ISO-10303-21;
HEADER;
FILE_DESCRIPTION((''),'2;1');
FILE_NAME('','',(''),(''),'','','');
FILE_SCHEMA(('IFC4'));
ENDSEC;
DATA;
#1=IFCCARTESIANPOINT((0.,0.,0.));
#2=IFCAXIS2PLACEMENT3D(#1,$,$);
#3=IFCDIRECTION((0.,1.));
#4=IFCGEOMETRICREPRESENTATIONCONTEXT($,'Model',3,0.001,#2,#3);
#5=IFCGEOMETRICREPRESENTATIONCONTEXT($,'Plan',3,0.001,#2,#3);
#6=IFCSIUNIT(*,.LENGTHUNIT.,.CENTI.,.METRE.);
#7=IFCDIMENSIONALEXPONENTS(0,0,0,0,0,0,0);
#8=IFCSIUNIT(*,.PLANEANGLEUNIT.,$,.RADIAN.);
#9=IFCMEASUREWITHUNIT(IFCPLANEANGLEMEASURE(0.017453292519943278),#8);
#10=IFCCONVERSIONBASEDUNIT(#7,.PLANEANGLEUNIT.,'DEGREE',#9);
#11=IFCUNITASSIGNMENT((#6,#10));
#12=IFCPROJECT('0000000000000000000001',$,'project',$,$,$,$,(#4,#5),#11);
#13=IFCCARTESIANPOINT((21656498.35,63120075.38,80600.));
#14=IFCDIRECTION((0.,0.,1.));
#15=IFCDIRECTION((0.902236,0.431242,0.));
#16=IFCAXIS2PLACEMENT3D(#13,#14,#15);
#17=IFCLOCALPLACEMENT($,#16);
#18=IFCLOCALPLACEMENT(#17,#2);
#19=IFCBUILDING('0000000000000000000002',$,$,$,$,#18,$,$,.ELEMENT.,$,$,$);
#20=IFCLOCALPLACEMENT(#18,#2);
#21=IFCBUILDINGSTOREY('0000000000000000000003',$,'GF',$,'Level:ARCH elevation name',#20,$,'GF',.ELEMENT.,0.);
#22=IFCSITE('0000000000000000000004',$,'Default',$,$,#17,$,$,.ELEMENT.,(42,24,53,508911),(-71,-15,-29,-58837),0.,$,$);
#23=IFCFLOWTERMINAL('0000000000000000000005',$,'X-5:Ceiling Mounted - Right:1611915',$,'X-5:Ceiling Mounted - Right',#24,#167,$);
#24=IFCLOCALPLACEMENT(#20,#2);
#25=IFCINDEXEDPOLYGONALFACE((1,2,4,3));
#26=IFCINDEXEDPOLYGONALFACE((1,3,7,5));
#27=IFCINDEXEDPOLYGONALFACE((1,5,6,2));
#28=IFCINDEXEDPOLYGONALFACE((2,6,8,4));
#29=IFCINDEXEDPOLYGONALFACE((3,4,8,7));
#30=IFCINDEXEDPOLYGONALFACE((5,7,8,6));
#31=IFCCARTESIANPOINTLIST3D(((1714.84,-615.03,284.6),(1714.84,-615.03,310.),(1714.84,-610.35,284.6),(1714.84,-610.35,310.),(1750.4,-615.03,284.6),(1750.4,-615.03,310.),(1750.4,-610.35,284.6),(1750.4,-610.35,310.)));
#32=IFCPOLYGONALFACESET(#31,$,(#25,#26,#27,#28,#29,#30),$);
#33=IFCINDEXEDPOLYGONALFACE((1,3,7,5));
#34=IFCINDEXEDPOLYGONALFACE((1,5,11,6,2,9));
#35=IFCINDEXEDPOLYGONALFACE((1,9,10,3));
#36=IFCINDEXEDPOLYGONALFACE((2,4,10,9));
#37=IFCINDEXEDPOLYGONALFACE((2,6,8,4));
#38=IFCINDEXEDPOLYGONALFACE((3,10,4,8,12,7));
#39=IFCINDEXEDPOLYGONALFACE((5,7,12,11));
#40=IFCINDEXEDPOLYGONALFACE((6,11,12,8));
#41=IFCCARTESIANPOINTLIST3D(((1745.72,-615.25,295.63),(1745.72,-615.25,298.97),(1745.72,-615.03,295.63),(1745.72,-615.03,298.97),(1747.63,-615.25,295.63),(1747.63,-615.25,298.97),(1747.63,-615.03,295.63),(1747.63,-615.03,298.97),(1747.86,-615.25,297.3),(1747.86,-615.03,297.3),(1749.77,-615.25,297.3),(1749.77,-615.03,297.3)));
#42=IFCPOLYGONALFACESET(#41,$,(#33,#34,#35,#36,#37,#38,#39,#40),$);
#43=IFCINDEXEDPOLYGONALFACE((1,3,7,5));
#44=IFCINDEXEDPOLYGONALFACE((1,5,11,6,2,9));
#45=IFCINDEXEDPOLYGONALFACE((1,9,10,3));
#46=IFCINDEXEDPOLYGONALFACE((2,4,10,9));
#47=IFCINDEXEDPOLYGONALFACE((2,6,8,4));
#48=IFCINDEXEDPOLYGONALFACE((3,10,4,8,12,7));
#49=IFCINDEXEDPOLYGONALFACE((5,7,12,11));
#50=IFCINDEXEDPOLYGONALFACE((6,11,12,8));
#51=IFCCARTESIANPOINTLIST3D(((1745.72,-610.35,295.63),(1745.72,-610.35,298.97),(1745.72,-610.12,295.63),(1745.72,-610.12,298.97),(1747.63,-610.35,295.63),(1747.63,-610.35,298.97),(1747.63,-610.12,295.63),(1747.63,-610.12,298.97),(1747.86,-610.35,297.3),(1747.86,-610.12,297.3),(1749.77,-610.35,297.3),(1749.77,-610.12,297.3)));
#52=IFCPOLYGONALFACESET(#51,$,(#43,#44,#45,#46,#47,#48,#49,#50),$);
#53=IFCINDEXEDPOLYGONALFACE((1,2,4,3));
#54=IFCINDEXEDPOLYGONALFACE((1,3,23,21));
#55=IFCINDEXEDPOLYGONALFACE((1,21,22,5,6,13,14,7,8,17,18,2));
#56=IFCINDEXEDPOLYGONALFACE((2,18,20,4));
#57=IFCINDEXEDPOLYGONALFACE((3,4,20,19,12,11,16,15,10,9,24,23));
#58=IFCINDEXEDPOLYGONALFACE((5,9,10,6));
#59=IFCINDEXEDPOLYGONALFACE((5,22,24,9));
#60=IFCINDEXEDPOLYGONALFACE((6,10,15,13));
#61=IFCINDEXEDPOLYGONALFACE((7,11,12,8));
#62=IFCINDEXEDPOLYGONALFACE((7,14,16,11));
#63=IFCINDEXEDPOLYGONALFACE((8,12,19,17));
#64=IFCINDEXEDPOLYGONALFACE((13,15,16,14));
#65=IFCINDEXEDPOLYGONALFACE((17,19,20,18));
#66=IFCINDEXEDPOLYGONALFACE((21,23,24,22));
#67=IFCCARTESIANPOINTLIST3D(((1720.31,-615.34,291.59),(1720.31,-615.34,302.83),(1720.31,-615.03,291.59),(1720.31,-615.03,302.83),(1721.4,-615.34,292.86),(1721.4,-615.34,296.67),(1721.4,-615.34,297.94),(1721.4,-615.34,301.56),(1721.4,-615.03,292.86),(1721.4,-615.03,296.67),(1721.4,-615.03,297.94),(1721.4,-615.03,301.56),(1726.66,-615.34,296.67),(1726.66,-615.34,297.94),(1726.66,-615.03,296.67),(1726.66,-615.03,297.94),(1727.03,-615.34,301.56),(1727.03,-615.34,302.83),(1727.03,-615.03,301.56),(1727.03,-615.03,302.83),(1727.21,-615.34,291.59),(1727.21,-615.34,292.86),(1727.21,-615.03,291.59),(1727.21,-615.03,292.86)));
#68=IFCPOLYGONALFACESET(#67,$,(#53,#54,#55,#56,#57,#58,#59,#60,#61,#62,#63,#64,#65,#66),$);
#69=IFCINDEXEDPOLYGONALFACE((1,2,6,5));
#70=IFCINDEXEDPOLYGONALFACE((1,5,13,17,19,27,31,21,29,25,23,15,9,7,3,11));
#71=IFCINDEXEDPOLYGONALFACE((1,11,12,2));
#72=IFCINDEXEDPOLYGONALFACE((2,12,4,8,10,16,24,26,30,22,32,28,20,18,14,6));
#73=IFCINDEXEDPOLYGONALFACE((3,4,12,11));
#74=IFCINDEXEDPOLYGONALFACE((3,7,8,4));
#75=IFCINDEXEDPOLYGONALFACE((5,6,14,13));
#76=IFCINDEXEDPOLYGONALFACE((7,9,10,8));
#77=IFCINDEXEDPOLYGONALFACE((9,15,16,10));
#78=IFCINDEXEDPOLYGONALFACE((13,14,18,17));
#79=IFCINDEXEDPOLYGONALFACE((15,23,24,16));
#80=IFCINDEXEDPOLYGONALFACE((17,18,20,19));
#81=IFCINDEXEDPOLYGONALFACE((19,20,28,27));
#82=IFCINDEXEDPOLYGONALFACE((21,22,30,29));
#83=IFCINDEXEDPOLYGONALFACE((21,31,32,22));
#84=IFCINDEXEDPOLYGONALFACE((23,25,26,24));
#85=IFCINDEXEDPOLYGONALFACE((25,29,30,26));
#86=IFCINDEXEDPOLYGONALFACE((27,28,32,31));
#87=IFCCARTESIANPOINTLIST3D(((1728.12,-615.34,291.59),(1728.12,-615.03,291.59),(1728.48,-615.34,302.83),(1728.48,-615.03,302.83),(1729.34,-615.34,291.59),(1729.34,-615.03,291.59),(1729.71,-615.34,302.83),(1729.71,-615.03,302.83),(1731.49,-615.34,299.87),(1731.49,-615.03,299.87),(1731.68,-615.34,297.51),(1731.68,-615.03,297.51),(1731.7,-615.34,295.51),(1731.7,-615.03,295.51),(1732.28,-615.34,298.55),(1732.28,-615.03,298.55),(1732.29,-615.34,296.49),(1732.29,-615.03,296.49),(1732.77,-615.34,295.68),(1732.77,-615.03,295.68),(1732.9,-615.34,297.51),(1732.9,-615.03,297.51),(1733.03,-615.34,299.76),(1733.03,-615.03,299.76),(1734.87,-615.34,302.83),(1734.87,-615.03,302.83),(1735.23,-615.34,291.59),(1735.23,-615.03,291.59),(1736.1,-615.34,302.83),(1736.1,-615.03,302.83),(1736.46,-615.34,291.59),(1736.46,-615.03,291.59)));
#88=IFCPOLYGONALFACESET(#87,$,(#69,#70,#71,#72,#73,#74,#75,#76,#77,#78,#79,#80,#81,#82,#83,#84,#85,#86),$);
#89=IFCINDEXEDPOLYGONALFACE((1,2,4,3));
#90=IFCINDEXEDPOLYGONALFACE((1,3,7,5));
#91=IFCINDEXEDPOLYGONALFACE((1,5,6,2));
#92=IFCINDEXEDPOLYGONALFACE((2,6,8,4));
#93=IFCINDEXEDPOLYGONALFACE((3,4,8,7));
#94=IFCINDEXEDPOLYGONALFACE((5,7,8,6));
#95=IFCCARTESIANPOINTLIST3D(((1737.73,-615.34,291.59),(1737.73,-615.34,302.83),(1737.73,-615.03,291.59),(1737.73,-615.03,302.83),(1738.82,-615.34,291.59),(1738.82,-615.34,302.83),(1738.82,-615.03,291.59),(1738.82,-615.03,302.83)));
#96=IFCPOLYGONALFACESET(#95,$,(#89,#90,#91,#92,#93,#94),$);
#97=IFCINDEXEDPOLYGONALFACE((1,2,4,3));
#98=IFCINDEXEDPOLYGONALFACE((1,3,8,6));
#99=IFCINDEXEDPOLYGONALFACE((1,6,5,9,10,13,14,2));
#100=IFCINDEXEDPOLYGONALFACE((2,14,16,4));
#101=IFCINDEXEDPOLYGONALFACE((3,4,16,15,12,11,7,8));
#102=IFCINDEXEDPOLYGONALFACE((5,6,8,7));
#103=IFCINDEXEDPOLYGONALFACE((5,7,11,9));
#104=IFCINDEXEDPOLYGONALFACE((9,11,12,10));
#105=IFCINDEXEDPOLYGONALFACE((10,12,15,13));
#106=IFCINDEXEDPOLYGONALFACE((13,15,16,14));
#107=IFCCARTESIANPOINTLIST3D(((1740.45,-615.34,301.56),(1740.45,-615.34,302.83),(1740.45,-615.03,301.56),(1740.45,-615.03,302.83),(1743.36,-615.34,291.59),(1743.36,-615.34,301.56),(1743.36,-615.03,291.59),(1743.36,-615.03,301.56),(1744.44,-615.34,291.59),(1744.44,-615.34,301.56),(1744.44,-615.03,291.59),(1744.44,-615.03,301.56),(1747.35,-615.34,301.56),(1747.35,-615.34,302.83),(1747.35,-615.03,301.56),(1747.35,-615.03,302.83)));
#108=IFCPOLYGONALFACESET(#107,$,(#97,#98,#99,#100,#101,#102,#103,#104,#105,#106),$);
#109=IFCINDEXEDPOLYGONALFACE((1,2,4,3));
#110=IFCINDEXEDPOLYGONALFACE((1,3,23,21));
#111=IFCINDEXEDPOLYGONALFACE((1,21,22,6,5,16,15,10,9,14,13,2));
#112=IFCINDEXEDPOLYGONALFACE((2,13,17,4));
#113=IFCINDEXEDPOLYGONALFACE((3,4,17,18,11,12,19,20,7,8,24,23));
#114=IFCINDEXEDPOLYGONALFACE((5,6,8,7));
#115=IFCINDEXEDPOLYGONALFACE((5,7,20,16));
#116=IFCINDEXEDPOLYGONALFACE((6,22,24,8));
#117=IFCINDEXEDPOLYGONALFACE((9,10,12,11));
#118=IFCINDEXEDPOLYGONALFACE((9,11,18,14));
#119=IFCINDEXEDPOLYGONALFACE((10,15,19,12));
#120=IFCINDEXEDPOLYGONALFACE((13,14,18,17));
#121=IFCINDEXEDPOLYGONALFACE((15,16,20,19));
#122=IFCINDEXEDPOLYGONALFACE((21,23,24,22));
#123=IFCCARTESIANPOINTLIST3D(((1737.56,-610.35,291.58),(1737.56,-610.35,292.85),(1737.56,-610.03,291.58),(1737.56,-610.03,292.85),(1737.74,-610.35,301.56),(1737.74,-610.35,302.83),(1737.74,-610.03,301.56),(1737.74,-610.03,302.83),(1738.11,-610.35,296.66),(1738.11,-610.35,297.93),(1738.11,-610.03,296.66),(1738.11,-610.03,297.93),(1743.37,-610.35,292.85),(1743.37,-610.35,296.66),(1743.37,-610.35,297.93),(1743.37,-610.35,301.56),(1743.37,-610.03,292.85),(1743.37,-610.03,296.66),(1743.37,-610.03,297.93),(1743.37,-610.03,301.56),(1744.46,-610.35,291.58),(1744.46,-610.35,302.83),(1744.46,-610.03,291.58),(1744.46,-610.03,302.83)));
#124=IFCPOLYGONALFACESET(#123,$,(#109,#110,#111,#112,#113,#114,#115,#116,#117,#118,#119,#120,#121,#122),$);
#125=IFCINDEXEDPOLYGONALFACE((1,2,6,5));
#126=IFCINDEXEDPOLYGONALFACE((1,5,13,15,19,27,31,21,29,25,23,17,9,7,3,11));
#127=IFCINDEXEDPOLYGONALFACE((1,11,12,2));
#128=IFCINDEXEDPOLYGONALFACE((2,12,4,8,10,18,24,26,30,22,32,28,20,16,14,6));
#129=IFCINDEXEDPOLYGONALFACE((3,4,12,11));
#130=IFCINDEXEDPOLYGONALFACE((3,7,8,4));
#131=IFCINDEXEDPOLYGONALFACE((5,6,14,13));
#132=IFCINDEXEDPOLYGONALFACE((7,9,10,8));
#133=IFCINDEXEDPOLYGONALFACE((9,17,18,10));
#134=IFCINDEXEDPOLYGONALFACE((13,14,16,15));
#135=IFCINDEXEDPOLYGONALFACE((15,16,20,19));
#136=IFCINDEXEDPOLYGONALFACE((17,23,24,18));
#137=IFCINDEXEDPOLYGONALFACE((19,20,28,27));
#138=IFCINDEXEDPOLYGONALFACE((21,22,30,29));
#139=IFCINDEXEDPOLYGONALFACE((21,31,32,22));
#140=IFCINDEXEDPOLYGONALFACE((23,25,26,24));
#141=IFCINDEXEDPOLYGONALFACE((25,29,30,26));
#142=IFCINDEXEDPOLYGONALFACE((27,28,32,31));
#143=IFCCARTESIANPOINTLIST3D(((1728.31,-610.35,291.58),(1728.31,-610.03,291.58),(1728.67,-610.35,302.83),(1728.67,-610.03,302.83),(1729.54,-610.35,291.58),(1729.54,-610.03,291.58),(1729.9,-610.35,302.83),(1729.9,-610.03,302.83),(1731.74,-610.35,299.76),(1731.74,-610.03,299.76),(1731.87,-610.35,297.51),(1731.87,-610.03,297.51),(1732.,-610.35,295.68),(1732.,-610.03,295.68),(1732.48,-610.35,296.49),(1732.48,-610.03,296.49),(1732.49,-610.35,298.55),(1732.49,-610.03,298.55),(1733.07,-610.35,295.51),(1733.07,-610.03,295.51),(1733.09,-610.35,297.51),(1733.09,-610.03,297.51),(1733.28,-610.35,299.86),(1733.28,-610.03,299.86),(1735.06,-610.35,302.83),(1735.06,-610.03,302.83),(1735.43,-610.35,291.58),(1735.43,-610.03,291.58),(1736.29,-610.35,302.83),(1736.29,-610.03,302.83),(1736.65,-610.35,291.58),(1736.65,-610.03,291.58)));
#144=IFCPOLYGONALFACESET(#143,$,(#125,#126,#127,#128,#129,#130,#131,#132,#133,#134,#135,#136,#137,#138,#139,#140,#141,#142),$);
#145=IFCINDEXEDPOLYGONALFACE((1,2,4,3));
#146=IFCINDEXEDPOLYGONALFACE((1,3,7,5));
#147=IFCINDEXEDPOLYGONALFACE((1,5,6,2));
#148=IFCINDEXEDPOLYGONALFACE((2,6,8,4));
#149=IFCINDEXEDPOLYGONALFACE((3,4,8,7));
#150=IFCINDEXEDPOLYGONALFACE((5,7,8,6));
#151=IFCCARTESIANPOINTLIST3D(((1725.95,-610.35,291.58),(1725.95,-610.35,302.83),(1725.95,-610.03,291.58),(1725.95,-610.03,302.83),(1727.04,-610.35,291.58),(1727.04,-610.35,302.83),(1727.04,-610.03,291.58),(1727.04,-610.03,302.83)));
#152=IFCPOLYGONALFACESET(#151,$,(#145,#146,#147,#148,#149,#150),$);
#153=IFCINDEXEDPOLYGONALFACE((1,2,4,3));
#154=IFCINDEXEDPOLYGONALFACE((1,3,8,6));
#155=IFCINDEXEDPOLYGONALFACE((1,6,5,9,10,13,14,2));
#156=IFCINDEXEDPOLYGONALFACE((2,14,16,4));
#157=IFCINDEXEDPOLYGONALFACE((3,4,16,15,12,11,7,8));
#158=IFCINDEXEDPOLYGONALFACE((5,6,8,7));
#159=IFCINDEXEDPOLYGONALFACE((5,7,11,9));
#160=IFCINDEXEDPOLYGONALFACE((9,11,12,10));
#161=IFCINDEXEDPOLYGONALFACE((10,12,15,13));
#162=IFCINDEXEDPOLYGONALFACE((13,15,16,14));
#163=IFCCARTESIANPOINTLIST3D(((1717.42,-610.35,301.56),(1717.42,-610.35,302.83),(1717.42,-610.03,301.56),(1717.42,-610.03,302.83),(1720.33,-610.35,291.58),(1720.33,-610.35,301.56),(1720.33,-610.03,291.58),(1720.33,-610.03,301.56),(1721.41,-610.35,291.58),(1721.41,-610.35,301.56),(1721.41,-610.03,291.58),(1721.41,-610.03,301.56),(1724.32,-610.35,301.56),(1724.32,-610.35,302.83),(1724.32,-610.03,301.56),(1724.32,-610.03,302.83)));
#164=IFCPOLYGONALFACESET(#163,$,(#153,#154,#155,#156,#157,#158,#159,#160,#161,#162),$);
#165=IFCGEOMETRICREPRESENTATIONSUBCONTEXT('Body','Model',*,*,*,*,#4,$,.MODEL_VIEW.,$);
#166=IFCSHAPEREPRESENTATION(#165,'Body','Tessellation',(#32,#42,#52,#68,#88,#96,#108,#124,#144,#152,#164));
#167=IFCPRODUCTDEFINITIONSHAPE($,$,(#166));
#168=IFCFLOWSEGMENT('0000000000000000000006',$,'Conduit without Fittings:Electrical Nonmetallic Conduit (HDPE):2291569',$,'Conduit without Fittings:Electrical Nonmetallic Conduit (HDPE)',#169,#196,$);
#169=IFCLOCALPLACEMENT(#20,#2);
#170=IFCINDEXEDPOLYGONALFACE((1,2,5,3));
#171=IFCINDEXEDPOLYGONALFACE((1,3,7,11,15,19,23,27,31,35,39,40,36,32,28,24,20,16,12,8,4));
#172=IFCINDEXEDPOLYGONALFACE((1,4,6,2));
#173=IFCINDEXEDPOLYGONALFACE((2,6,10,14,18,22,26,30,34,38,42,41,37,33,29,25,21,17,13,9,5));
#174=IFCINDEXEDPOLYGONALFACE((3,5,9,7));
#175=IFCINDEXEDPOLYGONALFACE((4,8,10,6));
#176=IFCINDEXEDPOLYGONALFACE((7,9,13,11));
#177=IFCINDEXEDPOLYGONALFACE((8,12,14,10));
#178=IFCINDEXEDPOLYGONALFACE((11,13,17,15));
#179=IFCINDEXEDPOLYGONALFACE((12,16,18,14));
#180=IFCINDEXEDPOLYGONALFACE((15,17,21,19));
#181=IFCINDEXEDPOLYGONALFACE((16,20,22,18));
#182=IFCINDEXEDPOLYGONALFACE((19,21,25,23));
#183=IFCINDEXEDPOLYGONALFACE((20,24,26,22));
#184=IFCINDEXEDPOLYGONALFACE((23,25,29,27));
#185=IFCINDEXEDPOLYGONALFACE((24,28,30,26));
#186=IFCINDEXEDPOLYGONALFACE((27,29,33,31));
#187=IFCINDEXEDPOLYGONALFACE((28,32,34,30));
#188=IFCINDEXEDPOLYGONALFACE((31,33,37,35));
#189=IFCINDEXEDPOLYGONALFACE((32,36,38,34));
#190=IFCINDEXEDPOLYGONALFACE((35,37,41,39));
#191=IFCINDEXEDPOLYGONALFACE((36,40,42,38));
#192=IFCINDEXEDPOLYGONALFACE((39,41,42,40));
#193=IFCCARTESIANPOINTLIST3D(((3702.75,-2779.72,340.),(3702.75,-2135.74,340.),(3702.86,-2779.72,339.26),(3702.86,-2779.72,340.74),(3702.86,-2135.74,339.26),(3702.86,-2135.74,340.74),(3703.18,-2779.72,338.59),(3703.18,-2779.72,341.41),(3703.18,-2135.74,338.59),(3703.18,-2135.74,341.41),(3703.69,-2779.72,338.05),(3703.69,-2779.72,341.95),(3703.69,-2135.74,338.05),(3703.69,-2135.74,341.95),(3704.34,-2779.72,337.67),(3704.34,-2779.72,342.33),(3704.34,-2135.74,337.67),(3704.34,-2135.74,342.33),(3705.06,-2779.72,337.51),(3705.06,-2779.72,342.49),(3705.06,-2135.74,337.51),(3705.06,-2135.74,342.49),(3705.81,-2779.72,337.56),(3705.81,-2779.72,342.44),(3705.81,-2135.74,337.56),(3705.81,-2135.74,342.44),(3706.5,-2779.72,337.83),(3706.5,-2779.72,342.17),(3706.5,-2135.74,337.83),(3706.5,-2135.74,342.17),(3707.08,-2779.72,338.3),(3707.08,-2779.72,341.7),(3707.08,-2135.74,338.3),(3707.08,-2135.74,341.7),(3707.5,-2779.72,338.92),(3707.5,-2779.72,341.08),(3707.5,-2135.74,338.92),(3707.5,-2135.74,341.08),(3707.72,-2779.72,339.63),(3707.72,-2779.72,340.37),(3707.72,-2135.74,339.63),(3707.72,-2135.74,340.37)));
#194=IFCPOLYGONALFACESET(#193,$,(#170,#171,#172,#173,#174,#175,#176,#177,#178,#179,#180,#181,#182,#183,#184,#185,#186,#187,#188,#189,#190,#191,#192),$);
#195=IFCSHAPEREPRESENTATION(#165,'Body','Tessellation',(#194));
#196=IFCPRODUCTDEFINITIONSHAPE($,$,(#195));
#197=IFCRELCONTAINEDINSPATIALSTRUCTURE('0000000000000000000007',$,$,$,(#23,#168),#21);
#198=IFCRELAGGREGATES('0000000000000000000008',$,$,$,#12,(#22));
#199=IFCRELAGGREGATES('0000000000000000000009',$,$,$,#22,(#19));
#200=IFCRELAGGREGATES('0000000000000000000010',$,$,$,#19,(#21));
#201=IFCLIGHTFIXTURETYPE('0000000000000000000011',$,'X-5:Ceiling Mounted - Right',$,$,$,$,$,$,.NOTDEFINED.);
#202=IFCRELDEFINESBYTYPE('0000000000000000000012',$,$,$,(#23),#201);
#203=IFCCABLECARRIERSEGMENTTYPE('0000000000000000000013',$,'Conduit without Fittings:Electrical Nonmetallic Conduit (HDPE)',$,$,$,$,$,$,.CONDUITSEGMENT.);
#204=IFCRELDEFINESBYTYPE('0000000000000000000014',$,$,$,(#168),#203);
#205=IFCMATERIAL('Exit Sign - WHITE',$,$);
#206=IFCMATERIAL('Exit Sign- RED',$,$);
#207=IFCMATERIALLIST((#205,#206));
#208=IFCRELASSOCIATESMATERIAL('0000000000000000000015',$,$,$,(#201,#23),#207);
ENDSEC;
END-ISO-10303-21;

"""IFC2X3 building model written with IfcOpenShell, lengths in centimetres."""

from ifc_helpers import new_model, entity, si_unit, converted_unit, direction, frame, frame_2d, origin, place, context, subcontext, project, spatial, polyline, rectangle, circle, outline, extrude, source, transform, mapped, material, material_list, type_object, type_shapes, element, save


model = new_model("IFC2X3")

# Units and contexts
model_context = context("Model", 3, precision=0.001, world=origin(), true_north=direction((0.0, 1.0)))
plan_context = context("Plan", 3, precision=0.001, world=origin(), true_north=direction((0.0, 1.0)))
body_context = subcontext(model_context, "Body", "Model", "MODEL_VIEW")
ifc_project = project(units=[si_unit("LENGTHUNIT", "METRE", prefix="CENTI"), converted_unit("PLANEANGLEUNIT", "DEGREE", entity("IfcPlaneAngleMeasure", 0.017453292519943278), si_unit("PLANEANGLEUNIT", "RADIAN"), dimensions=[0, 0, 0, 0, 0, 0, 0])], contexts=[model_context, plan_context])

# Site, building, storey
site_placement = place(None, frame((21656498.35, 63120075.38, 80600.0), z_axis=(0.0, 0.0, 1.0), x_axis=(0.902236, 0.431242, 0.0)))
site = spatial("IfcSite", under=ifc_project, at=site_placement, Name="Default", CompositionType="ELEMENT", RefLatitude=(42, 24, 53, 508911), RefLongitude=(-71, -15, -29, -58837), RefElevation=0.0)
building_placement = place(site_placement, origin())
building = spatial("IfcBuilding", under=site, at=building_placement, CompositionType="ELEMENT")
storey_placement = place(building_placement, origin())
storey = spatial("IfcBuildingStorey", under=building, at=storey_placement, Name="GF", ObjectType="Level:ARCH elevation name", LongName="GF", CompositionType="ELEMENT", Elevation=0.0)

# Flow terminal
ifc_material_1 = material(Name="Exit Sign - WHITE")
ifc_material_2 = material(Name="Exit Sign- RED")
ifc_material_list_1 = material_list([ifc_material_1, ifc_material_2])
light_fixture_type_1 = type_object("IfcLightFixtureType", Name="X-5:Ceiling Mounted - Right", PredefinedType="NOTDEFINED", material=ifc_material_list_1)
shared_shape_1 = source(origin(), body_context, "Body", "SweptSolid", [
    extrude(rectangle(XDim=4.68, YDim=35.56, at=frame_2d((0.0, 0.0), x_axis=(1.0, 0.0))), frame((0.0, 1.02, -25.4), z_axis=(0.0, 0.0, 1.0), x_axis=(0.0, 1.0, 0.0)), (0.0, 0.0, 1.0), 25.4),
    extrude(outline(polyline([(-0.84, -1.47), (1.88, -1.47), (1.22, 1.17), (-0.28, 2.34), (0.37, -0.29), (-2.34, -0.29), (-0.84, -1.47)])), frame((14.77, -1.54, -12.7), z_axis=(0.0, 1.0, 0.0), x_axis=(0.788011, 0.0, -0.615661)), (0.0, 0.0, 1.0), 0.22),
    extrude(outline(polyline([(-0.84, -1.47), (1.88, -1.47), (1.22, 1.17), (-0.28, 2.34), (0.37, -0.29), (-2.34, -0.29), (-0.84, -1.47)])), frame((14.77, 3.36, -12.7), z_axis=(0.0, 1.0, 0.0), x_axis=(0.788011, 0.0, -0.615661)), (0.0, 0.0, 1.0), 0.22),
    extrude(outline(polyline([(-5.65, -3.69), (5.59, -3.69), (5.59, 3.02), (4.32, 3.02), (4.32, -2.6), (0.7, -2.6), (0.7, 2.66), (-0.57, 2.66), (-0.57, -2.6), (-4.38, -2.6), (-4.38, 3.21), (-5.65, 3.21), (-5.65, -3.69)])), frame((-8.62, -1.63, -12.76), z_axis=(0.0, 1.0, 0.0), x_axis=(0.0, 0.0, 1.0)), (0.0, 0.0, 1.0), 0.32),
    extrude(outline(polyline([(-7.14, 0.57), (-6.5, -0.49), (-1.93, -0.48), (-0.78, -0.48), (-1.23, -1.32), (-3.47, -5.53), (-2.84, -6.59), (0.41, -0.48), (6.62, -0.48), (5.99, 0.57), (2.4, 0.57), (0.98, 0.58), (1.7, 1.94), (3.32, 5.0), (2.69, 6.05), (-0.22, 0.57), (-7.14, 0.57)])), frame((-0.34, -1.63, -12.59), z_axis=(0.0, -1.0, 0.0), x_axis=(0.515099, 0.0, 0.857131)), (0.0, 0.0, -1.0), 0.32),
    extrude(rectangle(XDim=0.32, YDim=1.09, at=frame_2d((0.0, 0.0), x_axis=(1.0, 0.0))), frame((5.65, -1.48, -18.41), z_axis=(0.0, 0.0, 1.0), x_axis=(0.0, 1.0, 0.0)), (0.0, 0.0, 1.0), 11.25),
    extrude(outline(polyline([(-7.8, 0.54), (-7.8, -0.54), (2.18, -0.54), (2.18, -3.45), (3.45, -3.45), (3.45, 3.45), (2.18, 3.45), (2.18, 0.54), (-7.8, 0.54)])), frame((11.28, -1.63, -10.61), z_axis=(0.0, -1.0, 0.0), x_axis=(0.0, 0.0, 1.0)), (0.0, 0.0, -1.0), 0.32),
    extrude(outline(polyline([(-3.69, -5.65), (3.21, -5.65), (3.21, -4.38), (-2.6, -4.38), (-2.6, -0.57), (2.66, -0.57), (2.66, 0.7), (-2.6, 0.7), (-2.6, 4.32), (3.02, 4.32), (3.02, 5.59), (-3.69, 5.59), (-3.69, -5.65)])), frame((8.14, 3.36, -12.76), z_axis=(0.0, 1.0, 0.0), x_axis=(-1.0, 0.0, 0.0)), (0.0, 0.0, 1.0), 0.32),
    extrude(outline(polyline([(-4.16, -5.82), (-2.93, -5.82), (-0.58, -1.9), (0.01, -0.92), (0.5, -1.73), (2.96, -5.82), (4.18, -5.82), (0.62, 0.1), (3.82, 5.42), (2.59, 5.42), (0.75, 2.35), (0.01, 1.14), (-0.79, 2.46), (-2.57, 5.42), (-3.8, 5.42), (-0.6, 0.1), (-4.16, -5.82)])), frame((-0.13, 3.36, -12.59), z_axis=(0.0, 1.0, 0.0), x_axis=(-1.0, 0.0, 0.0)), (0.0, 0.0, 1.0), 0.32),
    extrude(rectangle(XDim=0.32, YDim=1.09, at=frame_2d((0.0, 0.0), x_axis=(1.0, 0.0))), frame((-6.13, 3.52, -18.42), z_axis=(0.0, 0.0, 1.0), x_axis=(0.0, -1.0, 0.0)), (0.0, 0.0, 1.0), 11.25),
    extrude(outline(polyline([(-0.54, -7.8), (0.54, -7.8), (0.54, 2.18), (3.45, 2.18), (3.45, 3.45), (-3.45, 3.45), (-3.45, 2.18), (-0.54, 2.18), (-0.54, -7.8)])), frame((-11.75, 3.36, -10.62), z_axis=(0.0, 1.0, 0.0), x_axis=(-1.0, 0.0, 0.0)), (0.0, 0.0, 1.0), 0.32),
])
type_shapes(light_fixture_type_1, [shared_shape_1])
flow_terminal_1_placement = place(storey_placement, frame((1732.62, -613.71, 310.0)))
element("IfcFlowTerminal", 1, at=flow_terminal_1_placement, inside=storey, type_object=light_fixture_type_1, material=ifc_material_list_1, Name="X-5:Ceiling Mounted - Right:1611915", ObjectType="X-5:Ceiling Mounted - Right", context=body_context, shape_type="MappedRepresentation", body=[
    mapped(shared_shape_1, transform((0.0, 0.0, 0.0), scale=1.0)),
])

# Flow segment
cable_carrier_segment_type = type_object("IfcCableCarrierSegmentType", Name="Conduit without Fittings:Electrical Nonmetallic Conduit (HDPE)", PredefinedType="CONDUITSEGMENT")
flow_segment_placement = place(storey_placement, origin())
element("IfcFlowSegment", 2, at=flow_segment_placement, inside=storey, type_object=cable_carrier_segment_type, Name="Conduit without Fittings:Electrical Nonmetallic Conduit (HDPE):2291569", ObjectType="Conduit without Fittings:Electrical Nonmetallic Conduit (HDPE)", context=body_context, shape_type="SweptSolid", body=[
    extrude(circle(Radius=2.5, at=frame_2d((0.0, 0.0), x_axis=(1.0, 0.0))), frame((3705.25, -2779.72, 340.0), z_axis=(0.0, 1.0, 0.0), x_axis=(-1.0, 0.0, 0.0)), (0.0, 0.0, 1.0), 643.97),
])

save(model, "model.ifc")
